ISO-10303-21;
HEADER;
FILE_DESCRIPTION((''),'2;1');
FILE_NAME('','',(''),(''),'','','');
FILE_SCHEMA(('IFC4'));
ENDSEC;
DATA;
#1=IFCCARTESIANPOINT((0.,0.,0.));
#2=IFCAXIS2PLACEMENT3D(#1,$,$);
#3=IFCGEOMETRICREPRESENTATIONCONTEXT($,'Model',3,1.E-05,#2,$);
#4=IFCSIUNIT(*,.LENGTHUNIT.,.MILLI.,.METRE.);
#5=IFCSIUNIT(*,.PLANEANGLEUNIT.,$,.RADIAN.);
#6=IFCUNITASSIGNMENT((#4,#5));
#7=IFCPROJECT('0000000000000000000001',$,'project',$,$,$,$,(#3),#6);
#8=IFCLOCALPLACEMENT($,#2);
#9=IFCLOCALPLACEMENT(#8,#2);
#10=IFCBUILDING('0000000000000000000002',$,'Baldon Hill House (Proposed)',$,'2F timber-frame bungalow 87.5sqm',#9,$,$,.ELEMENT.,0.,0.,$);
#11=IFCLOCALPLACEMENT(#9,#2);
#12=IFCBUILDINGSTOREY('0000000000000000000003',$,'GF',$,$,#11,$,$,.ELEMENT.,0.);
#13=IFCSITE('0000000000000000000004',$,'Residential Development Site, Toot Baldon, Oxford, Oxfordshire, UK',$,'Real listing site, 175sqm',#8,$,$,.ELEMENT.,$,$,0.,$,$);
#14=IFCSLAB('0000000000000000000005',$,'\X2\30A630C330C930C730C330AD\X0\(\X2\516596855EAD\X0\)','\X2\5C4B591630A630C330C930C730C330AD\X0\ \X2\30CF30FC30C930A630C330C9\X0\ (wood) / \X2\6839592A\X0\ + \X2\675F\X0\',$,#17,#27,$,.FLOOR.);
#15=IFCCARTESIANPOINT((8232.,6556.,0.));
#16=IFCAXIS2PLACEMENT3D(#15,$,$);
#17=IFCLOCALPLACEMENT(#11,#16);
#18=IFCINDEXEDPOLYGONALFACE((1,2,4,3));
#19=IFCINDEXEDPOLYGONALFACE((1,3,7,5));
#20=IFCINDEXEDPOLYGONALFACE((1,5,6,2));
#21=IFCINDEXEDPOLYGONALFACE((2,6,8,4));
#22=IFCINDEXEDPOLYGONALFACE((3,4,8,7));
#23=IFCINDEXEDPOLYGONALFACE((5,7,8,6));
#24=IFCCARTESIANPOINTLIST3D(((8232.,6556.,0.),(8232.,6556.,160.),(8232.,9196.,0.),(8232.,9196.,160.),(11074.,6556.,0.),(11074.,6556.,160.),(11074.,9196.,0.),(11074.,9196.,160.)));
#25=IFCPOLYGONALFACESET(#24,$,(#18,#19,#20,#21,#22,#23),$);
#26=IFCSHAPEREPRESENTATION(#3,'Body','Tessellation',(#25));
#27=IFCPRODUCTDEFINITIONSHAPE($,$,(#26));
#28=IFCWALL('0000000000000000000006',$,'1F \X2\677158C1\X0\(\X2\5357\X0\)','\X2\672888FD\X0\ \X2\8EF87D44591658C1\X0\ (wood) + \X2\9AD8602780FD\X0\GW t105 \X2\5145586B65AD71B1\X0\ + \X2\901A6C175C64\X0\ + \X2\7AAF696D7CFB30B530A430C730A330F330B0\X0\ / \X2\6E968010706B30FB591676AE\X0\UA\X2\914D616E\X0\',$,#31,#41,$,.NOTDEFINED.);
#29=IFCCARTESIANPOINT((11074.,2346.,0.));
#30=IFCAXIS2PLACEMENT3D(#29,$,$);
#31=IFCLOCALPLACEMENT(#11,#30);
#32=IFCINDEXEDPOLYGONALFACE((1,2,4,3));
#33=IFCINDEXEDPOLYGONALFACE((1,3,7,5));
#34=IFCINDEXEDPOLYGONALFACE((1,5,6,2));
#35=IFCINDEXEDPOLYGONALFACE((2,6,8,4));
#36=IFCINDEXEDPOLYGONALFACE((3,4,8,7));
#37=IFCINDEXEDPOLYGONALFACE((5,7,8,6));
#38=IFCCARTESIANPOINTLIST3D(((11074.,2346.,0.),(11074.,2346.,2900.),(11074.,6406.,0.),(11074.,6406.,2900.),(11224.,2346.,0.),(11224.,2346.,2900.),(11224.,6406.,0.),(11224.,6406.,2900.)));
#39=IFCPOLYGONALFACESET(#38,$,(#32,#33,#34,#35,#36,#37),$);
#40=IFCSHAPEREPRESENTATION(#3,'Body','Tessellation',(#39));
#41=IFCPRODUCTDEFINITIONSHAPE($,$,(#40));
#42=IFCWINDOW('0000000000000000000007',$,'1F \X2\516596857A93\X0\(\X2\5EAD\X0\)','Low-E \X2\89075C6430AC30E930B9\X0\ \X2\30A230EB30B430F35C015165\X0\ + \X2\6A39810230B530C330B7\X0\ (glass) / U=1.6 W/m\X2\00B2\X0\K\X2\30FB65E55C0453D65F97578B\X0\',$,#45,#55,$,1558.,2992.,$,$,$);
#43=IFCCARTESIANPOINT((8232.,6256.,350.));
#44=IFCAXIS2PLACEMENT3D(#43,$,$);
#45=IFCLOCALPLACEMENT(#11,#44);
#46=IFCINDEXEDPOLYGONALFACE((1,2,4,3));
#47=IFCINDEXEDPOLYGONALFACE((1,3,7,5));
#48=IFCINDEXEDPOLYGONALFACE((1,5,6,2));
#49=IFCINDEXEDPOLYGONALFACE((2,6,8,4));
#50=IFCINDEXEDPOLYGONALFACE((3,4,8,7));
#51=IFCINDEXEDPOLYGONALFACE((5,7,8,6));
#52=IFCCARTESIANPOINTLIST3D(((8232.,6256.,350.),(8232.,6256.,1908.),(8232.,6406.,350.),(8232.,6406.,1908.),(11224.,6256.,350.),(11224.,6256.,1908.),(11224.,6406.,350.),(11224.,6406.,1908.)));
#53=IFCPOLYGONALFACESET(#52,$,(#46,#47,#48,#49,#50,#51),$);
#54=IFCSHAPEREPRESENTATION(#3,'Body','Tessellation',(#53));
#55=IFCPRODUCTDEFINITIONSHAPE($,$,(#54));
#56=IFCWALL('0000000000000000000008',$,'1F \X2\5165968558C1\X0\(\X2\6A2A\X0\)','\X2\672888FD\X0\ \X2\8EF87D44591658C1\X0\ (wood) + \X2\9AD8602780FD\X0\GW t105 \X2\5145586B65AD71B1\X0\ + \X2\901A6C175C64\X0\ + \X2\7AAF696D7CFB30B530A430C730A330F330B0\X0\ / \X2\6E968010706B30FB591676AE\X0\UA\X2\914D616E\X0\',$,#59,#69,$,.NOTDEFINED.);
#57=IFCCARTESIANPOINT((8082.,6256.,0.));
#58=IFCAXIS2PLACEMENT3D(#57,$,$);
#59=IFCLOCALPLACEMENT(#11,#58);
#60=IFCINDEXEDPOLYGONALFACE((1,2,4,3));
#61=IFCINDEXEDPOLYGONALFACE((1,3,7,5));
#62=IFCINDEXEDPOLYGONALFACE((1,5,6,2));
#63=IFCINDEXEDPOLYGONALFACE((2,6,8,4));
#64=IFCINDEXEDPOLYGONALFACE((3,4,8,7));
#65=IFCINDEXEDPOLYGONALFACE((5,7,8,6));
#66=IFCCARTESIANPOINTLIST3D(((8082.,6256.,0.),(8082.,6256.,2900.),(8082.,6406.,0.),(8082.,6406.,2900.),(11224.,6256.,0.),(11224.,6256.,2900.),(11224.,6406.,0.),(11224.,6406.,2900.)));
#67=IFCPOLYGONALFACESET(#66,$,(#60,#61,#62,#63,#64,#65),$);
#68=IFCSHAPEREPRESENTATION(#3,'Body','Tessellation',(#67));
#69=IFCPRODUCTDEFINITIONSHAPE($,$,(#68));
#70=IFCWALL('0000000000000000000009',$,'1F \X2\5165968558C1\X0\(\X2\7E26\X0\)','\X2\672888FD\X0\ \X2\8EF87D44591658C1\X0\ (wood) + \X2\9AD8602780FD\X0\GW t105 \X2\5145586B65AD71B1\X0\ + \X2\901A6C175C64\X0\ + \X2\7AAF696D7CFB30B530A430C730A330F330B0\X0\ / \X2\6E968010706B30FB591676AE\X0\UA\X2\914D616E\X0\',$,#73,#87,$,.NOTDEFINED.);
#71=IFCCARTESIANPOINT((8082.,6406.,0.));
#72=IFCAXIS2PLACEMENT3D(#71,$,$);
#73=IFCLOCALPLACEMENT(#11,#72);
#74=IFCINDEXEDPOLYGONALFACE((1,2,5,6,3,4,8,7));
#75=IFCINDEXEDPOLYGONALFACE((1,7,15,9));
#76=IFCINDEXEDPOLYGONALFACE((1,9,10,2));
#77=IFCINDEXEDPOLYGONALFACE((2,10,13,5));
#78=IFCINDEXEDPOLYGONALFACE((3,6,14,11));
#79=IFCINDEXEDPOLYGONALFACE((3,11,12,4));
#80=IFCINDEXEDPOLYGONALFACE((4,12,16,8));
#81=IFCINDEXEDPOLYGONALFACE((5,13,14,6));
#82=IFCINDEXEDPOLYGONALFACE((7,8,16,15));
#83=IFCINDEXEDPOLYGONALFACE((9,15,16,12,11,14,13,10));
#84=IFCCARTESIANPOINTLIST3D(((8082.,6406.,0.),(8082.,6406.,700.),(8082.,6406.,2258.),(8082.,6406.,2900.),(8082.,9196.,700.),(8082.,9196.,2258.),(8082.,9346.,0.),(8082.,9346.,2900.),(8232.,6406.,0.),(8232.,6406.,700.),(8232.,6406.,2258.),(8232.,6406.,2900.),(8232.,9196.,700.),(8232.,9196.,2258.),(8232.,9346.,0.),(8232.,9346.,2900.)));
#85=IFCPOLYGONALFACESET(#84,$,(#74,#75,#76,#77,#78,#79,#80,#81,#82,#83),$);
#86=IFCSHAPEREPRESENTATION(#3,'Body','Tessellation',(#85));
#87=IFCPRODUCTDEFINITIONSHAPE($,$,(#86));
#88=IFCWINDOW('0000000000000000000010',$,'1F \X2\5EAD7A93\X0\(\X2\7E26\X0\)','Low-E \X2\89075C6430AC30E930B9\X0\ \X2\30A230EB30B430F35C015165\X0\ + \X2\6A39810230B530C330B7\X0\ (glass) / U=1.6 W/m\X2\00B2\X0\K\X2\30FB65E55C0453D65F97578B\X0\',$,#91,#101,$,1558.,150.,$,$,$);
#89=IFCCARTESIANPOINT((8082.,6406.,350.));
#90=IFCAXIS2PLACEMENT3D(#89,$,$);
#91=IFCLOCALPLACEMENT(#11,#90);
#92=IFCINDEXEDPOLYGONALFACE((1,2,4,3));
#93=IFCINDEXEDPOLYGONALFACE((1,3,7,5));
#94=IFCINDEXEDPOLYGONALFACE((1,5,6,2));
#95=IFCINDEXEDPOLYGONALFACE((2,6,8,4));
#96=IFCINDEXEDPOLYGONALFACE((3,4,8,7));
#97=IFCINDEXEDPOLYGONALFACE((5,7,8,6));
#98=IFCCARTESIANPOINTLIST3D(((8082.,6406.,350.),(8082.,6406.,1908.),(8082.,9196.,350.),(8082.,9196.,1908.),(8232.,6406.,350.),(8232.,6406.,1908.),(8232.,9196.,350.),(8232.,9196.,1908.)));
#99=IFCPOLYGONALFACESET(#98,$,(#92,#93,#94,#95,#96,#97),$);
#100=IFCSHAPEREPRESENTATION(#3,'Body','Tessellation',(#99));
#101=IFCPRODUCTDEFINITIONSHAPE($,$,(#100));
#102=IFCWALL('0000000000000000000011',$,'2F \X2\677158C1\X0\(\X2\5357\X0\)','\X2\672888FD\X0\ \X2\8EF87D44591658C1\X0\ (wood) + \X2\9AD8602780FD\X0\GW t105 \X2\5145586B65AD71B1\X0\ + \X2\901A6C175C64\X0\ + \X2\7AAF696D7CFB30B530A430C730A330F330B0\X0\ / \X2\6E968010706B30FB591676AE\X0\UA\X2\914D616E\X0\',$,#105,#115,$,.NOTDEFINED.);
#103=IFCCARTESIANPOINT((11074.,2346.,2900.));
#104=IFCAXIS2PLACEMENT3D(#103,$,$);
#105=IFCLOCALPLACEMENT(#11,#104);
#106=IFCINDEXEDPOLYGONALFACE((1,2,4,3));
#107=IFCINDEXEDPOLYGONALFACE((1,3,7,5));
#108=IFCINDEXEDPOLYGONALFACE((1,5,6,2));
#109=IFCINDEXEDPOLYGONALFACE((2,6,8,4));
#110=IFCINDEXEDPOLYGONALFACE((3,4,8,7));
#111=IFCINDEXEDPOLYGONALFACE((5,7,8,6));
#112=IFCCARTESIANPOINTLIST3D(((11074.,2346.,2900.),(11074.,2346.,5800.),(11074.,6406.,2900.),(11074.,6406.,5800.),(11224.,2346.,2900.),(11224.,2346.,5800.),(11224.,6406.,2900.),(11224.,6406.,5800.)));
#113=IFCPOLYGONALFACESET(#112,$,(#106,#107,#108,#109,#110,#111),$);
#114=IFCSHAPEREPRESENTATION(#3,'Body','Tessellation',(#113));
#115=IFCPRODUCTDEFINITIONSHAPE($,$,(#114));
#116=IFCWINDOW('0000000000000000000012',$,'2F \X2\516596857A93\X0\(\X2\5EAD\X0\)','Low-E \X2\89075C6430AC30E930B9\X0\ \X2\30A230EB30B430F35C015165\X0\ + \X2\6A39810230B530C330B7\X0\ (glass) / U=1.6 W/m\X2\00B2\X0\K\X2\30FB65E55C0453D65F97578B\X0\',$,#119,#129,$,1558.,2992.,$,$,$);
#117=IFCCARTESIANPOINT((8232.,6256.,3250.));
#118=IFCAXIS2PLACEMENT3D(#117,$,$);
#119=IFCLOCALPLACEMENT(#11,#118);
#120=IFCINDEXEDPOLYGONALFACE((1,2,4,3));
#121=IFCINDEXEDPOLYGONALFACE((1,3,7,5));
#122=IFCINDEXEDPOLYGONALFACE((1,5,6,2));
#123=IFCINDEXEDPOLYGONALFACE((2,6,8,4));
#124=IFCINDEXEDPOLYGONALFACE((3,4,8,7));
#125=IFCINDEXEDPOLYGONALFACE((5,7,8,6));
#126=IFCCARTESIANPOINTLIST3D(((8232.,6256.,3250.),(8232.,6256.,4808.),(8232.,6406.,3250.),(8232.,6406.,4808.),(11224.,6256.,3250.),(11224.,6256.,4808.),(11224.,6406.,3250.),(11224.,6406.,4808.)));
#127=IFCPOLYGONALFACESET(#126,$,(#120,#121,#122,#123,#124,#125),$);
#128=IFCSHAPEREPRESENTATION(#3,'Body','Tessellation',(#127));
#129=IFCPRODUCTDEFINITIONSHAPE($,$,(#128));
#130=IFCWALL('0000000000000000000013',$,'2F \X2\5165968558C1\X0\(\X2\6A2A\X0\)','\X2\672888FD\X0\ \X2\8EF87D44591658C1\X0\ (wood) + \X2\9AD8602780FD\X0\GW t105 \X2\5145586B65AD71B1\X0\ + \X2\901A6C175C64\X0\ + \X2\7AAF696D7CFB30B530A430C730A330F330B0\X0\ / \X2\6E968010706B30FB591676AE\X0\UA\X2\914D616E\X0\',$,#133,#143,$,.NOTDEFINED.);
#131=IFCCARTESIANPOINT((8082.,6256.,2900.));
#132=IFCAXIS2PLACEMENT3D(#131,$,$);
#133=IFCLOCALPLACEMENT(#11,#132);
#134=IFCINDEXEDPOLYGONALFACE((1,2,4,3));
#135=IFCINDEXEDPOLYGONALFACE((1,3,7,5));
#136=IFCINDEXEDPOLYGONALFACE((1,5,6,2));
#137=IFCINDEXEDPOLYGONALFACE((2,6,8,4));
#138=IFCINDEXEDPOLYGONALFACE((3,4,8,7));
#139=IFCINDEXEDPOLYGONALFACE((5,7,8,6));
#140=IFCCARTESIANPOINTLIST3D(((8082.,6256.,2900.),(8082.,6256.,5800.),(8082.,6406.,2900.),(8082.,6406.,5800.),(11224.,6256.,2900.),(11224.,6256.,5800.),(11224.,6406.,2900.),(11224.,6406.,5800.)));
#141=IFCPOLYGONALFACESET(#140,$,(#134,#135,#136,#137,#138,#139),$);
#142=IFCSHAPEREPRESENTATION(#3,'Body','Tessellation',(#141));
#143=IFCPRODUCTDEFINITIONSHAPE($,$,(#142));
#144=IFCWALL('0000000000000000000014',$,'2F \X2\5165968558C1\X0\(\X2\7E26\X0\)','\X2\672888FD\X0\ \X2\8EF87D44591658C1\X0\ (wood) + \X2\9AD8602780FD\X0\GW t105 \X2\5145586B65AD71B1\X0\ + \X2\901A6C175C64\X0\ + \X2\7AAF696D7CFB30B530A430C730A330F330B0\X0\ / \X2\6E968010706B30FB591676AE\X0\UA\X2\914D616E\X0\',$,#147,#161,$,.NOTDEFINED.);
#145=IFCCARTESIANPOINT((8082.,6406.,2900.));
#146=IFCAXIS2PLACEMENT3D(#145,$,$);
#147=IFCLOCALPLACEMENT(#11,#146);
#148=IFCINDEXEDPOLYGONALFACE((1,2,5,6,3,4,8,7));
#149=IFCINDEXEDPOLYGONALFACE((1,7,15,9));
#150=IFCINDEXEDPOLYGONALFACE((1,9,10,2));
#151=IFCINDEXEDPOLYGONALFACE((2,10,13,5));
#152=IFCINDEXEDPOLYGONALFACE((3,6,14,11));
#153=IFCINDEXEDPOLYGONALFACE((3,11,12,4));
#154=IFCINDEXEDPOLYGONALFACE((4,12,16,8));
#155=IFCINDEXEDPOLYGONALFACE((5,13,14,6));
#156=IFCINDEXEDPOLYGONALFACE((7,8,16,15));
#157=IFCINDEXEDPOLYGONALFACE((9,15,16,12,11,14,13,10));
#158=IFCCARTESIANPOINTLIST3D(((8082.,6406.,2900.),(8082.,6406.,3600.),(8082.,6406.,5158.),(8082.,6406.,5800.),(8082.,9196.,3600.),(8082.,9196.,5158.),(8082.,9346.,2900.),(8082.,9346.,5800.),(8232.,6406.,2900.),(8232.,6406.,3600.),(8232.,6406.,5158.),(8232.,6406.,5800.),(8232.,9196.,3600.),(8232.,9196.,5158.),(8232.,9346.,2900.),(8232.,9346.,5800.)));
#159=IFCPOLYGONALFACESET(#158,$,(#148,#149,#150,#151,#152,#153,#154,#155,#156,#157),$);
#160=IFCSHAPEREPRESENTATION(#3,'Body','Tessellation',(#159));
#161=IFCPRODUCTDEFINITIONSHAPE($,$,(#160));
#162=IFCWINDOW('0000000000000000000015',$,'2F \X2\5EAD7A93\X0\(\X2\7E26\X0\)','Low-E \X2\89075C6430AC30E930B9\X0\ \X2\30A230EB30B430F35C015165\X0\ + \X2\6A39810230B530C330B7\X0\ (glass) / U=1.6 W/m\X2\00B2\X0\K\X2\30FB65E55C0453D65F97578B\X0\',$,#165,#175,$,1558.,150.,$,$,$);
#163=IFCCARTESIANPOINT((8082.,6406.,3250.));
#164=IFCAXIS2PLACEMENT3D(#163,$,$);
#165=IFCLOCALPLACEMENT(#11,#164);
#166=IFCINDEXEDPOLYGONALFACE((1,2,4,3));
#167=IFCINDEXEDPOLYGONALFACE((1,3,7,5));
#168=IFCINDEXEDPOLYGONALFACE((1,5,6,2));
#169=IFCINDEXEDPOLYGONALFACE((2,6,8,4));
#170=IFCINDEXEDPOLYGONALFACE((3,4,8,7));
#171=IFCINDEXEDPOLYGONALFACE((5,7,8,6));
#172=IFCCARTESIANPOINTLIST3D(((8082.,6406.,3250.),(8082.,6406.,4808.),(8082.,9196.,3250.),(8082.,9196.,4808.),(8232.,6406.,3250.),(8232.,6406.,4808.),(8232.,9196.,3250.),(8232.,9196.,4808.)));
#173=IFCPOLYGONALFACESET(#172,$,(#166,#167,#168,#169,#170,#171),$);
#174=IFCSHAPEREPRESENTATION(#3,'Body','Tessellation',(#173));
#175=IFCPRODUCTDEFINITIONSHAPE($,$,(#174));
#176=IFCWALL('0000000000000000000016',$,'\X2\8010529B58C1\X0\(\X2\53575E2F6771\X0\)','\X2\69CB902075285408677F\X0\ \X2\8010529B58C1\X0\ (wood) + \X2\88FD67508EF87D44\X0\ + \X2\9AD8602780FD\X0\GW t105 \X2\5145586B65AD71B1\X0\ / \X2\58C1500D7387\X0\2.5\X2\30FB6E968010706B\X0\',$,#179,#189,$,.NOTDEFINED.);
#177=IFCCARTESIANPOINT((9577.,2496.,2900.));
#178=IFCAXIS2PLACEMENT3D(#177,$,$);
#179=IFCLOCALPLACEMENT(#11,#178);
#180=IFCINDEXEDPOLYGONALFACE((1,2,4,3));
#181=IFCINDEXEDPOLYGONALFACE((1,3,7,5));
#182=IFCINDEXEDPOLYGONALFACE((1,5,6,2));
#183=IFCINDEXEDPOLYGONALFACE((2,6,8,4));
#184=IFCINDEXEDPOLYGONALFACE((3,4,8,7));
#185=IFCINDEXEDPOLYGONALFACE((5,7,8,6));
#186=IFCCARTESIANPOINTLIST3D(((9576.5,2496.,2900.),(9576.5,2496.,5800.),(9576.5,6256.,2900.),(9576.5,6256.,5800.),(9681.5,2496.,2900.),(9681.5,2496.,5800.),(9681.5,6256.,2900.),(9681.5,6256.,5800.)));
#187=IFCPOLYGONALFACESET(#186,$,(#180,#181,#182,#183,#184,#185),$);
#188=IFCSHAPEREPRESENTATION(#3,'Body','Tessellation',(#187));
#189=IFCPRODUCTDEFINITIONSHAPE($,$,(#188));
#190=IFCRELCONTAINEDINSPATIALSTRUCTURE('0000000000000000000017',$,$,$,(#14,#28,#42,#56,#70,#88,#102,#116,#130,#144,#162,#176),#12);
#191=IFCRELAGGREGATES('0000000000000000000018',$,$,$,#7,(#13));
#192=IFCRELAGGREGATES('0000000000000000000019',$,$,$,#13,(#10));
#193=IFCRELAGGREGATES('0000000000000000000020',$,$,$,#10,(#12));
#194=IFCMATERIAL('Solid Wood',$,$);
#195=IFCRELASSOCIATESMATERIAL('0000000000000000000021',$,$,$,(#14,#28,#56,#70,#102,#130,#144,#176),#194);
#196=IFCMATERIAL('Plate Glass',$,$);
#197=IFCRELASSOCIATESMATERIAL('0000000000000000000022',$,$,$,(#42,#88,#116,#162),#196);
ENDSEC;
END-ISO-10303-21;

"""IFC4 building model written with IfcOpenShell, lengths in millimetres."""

from ifc_helpers import new_model, si_unit, frame, frame_2d, origin, place, context, project, spatial, rectangle, extrude, material, element, fill, save


model = new_model("IFC4")

# Units and contexts
model_context = context("Model", 3, precision=1e-05, world=origin())
ifc_project = project(units=[si_unit("LENGTHUNIT", "METRE", prefix="MILLI"), si_unit("PLANEANGLEUNIT", "RADIAN")], contexts=[model_context])

# Site, building, storey
site_placement = place(None, origin())
site = spatial("IfcSite", under=ifc_project, at=site_placement, Name="Residential Development Site, Toot Baldon, Oxford, Oxfordshire, UK", ObjectType="Real listing site, 175sqm", CompositionType="ELEMENT", RefElevation=0.0)
building_placement = place(site_placement, origin())
building = spatial("IfcBuilding", under=site, at=building_placement, Name="Baldon Hill House (Proposed)", ObjectType="2F timber-frame bungalow 87.5sqm", CompositionType="ELEMENT", ElevationOfRefHeight=0.0, ElevationOfTerrain=0.0)
storey_placement = place(building_placement, origin())
storey = spatial("IfcBuildingStorey", under=building, at=storey_placement, Name="GF", CompositionType="ELEMENT", Elevation=0.0)

# Slab
ifc_material_1 = material(Name="Solid Wood")
slab_placement = place(storey_placement, frame((8232.0, 6556.0, 0.0)))
element("IfcSlab", 1, at=slab_placement, inside=storey, material=ifc_material_1, Name="ウッドデッキ(入隅庭)", Description="屋外ウッドデッキ ハードウッド (wood) / 根太 + 束", PredefinedType="FLOOR", context=model_context, shape_type="SweptSolid", body=[
    extrude(rectangle(XDim=2842.0, YDim=2640.0, at=frame_2d((1421.0, 1320.0))), frame((8232.0, 6556.0, 0.0)), (0.0, 0.0, 1.0), 160.0),
])

# Wall, opening, window
wall_1_placement = place(storey_placement, frame((11074.0, 2346.0, 0.0)))
wall_1 = element("IfcWall", 2, at=wall_1_placement, inside=storey, material=ifc_material_1, Name="1F 東壁(南)", Description="木製 軸組外壁 (wood) + 高性能GW t105 充填断熱 + 通気層 + 窯業系サイディング / 準耐火・外皮UA配慮", PredefinedType="NOTDEFINED", context=model_context, shape_type="SweptSolid", body=[
    extrude(rectangle(XDim=150.0, YDim=4060.0, at=frame_2d((75.0, 2030.0))), frame((11074.0, 2346.0, 0.0)), (0.0, 0.0, 1.0), 2900.0),
])
opening_1_placement = place(storey_placement, frame((8232.0, 6256.0, 350.0)))
opening_1 = element("IfcOpeningElement", 3, at=opening_1_placement, cuts=wall_1, PredefinedType="NOTDEFINED", context=model_context, shape_type="SweptSolid", body=[
    extrude(rectangle(XDim=2992.0, YDim=150.0, at=frame_2d((1496.0, 75.0))), frame((8232.0, 6256.0, 350.0)), (0.0, 0.0, 1.0), 1558.0),
])
ifc_material_2 = material(Name="Plate Glass")
window_1_placement = place(storey_placement, frame((8232.0, 6256.0, 350.0)))
window_1 = element("IfcWindow", 4, at=window_1_placement, inside=storey, material=ifc_material_2, Name="1F 入隅窓(庭)", Description="Low-E 複層ガラス アルゴン封入 + 樹脂サッシ (glass) / U=1.6 W/m²K・日射取得型", OverallHeight=1558.0, OverallWidth=2992.0, context=model_context, shape_type="SweptSolid", body=[
    extrude(rectangle(XDim=2992.0, YDim=150.0, at=frame_2d((1496.0, 75.0))), frame((8232.0, 6256.0, 350.0)), (0.0, 0.0, 1.0), 1558.0),
])
fill(opening_1, window_1)

# Wall
wall_2_placement = place(storey_placement, frame((8082.0, 6256.0, 0.0)))
element("IfcWall", 5, at=wall_2_placement, inside=storey, material=ifc_material_1, Name="1F 入隅壁(横)", Description="木製 軸組外壁 (wood) + 高性能GW t105 充填断熱 + 通気層 + 窯業系サイディング / 準耐火・外皮UA配慮", PredefinedType="NOTDEFINED", context=model_context, shape_type="SweptSolid", body=[
    extrude(rectangle(XDim=3142.0, YDim=150.0, at=frame_2d((1571.0, 75.0))), frame((8082.0, 6256.0, 0.0)), (0.0, 0.0, 1.0), 2900.0),
])

# Wall, opening, window
wall_3_placement = place(storey_placement, frame((8082.0, 6406.0, 0.0)))
wall_3 = element("IfcWall", 6, at=wall_3_placement, inside=storey, material=ifc_material_1, Name="1F 入隅壁(縦)", Description="木製 軸組外壁 (wood) + 高性能GW t105 充填断熱 + 通気層 + 窯業系サイディング / 準耐火・外皮UA配慮", PredefinedType="NOTDEFINED", context=model_context, shape_type="SweptSolid", body=[
    extrude(rectangle(XDim=150.0, YDim=2940.0, at=frame_2d((75.0, 1470.0))), frame((8082.0, 6406.0, 0.0)), (0.0, 0.0, 1.0), 2900.0),
])
opening_2_placement = place(storey_placement, frame((8082.0, 6406.0, 350.0)))
opening_2 = element("IfcOpeningElement", 7, at=opening_2_placement, cuts=wall_3, PredefinedType="NOTDEFINED", context=model_context, shape_type="SweptSolid", body=[
    extrude(rectangle(XDim=150.0, YDim=2790.0, at=frame_2d((75.0, 1395.0))), frame((8082.0, 6406.0, 350.0)), (0.0, 0.0, 1.0), 1558.0),
])
window_2_placement = place(storey_placement, frame((8082.0, 6406.0, 350.0)))
window_2 = element("IfcWindow", 8, at=window_2_placement, inside=storey, material=ifc_material_2, Name="1F 庭窓(縦)", Description="Low-E 複層ガラス アルゴン封入 + 樹脂サッシ (glass) / U=1.6 W/m²K・日射取得型", OverallHeight=1558.0, OverallWidth=150.0, context=model_context, shape_type="SweptSolid", body=[
    extrude(rectangle(XDim=150.0, YDim=2790.0, at=frame_2d((75.0, 1395.0))), frame((8082.0, 6406.0, 350.0)), (0.0, 0.0, 1.0), 1558.0),
])
fill(opening_2, window_2)

# Wall, opening, window
wall_4_placement = place(storey_placement, frame((11074.0, 2346.0, 2900.0)))
wall_4 = element("IfcWall", 9, at=wall_4_placement, inside=storey, material=ifc_material_1, Name="2F 東壁(南)", Description="木製 軸組外壁 (wood) + 高性能GW t105 充填断熱 + 通気層 + 窯業系サイディング / 準耐火・外皮UA配慮", PredefinedType="NOTDEFINED", context=model_context, shape_type="SweptSolid", body=[
    extrude(rectangle(XDim=150.0, YDim=4060.0, at=frame_2d((75.0, 2030.0))), frame((11074.0, 2346.0, 2900.0)), (0.0, 0.0, 1.0), 2900.0),
])
opening_3_placement = place(storey_placement, frame((8232.0, 6256.0, 3250.0)))
opening_3 = element("IfcOpeningElement", 10, at=opening_3_placement, cuts=wall_4, PredefinedType="NOTDEFINED", context=model_context, shape_type="SweptSolid", body=[
    extrude(rectangle(XDim=2992.0, YDim=150.0, at=frame_2d((1496.0, 75.0))), frame((8232.0, 6256.0, 3250.0)), (0.0, 0.0, 1.0), 1558.0),
])
window_3_placement = place(storey_placement, frame((8232.0, 6256.0, 3250.0)))
window_3 = element("IfcWindow", 11, at=window_3_placement, inside=storey, material=ifc_material_2, Name="2F 入隅窓(庭)", Description="Low-E 複層ガラス アルゴン封入 + 樹脂サッシ (glass) / U=1.6 W/m²K・日射取得型", OverallHeight=1558.0, OverallWidth=2992.0, context=model_context, shape_type="SweptSolid", body=[
    extrude(rectangle(XDim=2992.0, YDim=150.0, at=frame_2d((1496.0, 75.0))), frame((8232.0, 6256.0, 3250.0)), (0.0, 0.0, 1.0), 1558.0),
])
fill(opening_3, window_3)

# Wall
wall_5_placement = place(storey_placement, frame((8082.0, 6256.0, 2900.0)))
element("IfcWall", 12, at=wall_5_placement, inside=storey, material=ifc_material_1, Name="2F 入隅壁(横)", Description="木製 軸組外壁 (wood) + 高性能GW t105 充填断熱 + 通気層 + 窯業系サイディング / 準耐火・外皮UA配慮", PredefinedType="NOTDEFINED", context=model_context, shape_type="SweptSolid", body=[
    extrude(rectangle(XDim=3142.0, YDim=150.0, at=frame_2d((1571.0, 75.0))), frame((8082.0, 6256.0, 2900.0)), (0.0, 0.0, 1.0), 2900.0),
])

# Wall, opening, window
wall_6_placement = place(storey_placement, frame((8082.0, 6406.0, 2900.0)))
wall_6 = element("IfcWall", 13, at=wall_6_placement, inside=storey, material=ifc_material_1, Name="2F 入隅壁(縦)", Description="木製 軸組外壁 (wood) + 高性能GW t105 充填断熱 + 通気層 + 窯業系サイディング / 準耐火・外皮UA配慮", PredefinedType="NOTDEFINED", context=model_context, shape_type="SweptSolid", body=[
    extrude(rectangle(XDim=150.0, YDim=2940.0, at=frame_2d((75.0, 1470.0))), frame((8082.0, 6406.0, 2900.0)), (0.0, 0.0, 1.0), 2900.0),
])
opening_4_placement = place(storey_placement, frame((8082.0, 6406.0, 3250.0)))
opening_4 = element("IfcOpeningElement", 14, at=opening_4_placement, cuts=wall_6, PredefinedType="NOTDEFINED", context=model_context, shape_type="SweptSolid", body=[
    extrude(rectangle(XDim=150.0, YDim=2790.0, at=frame_2d((75.0, 1395.0))), frame((8082.0, 6406.0, 3250.0)), (0.0, 0.0, 1.0), 1558.0),
])
window_4_placement = place(storey_placement, frame((8082.0, 6406.0, 3250.0)))
window_4 = element("IfcWindow", 15, at=window_4_placement, inside=storey, material=ifc_material_2, Name="2F 庭窓(縦)", Description="Low-E 複層ガラス アルゴン封入 + 樹脂サッシ (glass) / U=1.6 W/m²K・日射取得型", OverallHeight=1558.0, OverallWidth=150.0, context=model_context, shape_type="SweptSolid", body=[
    extrude(rectangle(XDim=150.0, YDim=2790.0, at=frame_2d((75.0, 1395.0))), frame((8082.0, 6406.0, 3250.0)), (0.0, 0.0, 1.0), 1558.0),
])
fill(opening_4, window_4)

# Wall
wall_7_placement = place(storey_placement, frame((9577.0, 2496.0, 2900.0)))
element("IfcWall", 16, at=wall_7_placement, inside=storey, material=ifc_material_1, Name="耐力壁(南帯東)", Description="構造用合板 耐力壁 (wood) + 製材軸組 + 高性能GW t105 充填断熱 / 壁倍率2.5・準耐火", PredefinedType="NOTDEFINED", context=model_context, shape_type="SweptSolid", body=[
    extrude(rectangle(XDim=105.0, YDim=3760.0, at=frame_2d((52.0, 1880.0))), frame((9577.0, 2496.0, 2900.0)), (0.0, 0.0, 1.0), 2900.0),
])

save(model, "model.ifc")
